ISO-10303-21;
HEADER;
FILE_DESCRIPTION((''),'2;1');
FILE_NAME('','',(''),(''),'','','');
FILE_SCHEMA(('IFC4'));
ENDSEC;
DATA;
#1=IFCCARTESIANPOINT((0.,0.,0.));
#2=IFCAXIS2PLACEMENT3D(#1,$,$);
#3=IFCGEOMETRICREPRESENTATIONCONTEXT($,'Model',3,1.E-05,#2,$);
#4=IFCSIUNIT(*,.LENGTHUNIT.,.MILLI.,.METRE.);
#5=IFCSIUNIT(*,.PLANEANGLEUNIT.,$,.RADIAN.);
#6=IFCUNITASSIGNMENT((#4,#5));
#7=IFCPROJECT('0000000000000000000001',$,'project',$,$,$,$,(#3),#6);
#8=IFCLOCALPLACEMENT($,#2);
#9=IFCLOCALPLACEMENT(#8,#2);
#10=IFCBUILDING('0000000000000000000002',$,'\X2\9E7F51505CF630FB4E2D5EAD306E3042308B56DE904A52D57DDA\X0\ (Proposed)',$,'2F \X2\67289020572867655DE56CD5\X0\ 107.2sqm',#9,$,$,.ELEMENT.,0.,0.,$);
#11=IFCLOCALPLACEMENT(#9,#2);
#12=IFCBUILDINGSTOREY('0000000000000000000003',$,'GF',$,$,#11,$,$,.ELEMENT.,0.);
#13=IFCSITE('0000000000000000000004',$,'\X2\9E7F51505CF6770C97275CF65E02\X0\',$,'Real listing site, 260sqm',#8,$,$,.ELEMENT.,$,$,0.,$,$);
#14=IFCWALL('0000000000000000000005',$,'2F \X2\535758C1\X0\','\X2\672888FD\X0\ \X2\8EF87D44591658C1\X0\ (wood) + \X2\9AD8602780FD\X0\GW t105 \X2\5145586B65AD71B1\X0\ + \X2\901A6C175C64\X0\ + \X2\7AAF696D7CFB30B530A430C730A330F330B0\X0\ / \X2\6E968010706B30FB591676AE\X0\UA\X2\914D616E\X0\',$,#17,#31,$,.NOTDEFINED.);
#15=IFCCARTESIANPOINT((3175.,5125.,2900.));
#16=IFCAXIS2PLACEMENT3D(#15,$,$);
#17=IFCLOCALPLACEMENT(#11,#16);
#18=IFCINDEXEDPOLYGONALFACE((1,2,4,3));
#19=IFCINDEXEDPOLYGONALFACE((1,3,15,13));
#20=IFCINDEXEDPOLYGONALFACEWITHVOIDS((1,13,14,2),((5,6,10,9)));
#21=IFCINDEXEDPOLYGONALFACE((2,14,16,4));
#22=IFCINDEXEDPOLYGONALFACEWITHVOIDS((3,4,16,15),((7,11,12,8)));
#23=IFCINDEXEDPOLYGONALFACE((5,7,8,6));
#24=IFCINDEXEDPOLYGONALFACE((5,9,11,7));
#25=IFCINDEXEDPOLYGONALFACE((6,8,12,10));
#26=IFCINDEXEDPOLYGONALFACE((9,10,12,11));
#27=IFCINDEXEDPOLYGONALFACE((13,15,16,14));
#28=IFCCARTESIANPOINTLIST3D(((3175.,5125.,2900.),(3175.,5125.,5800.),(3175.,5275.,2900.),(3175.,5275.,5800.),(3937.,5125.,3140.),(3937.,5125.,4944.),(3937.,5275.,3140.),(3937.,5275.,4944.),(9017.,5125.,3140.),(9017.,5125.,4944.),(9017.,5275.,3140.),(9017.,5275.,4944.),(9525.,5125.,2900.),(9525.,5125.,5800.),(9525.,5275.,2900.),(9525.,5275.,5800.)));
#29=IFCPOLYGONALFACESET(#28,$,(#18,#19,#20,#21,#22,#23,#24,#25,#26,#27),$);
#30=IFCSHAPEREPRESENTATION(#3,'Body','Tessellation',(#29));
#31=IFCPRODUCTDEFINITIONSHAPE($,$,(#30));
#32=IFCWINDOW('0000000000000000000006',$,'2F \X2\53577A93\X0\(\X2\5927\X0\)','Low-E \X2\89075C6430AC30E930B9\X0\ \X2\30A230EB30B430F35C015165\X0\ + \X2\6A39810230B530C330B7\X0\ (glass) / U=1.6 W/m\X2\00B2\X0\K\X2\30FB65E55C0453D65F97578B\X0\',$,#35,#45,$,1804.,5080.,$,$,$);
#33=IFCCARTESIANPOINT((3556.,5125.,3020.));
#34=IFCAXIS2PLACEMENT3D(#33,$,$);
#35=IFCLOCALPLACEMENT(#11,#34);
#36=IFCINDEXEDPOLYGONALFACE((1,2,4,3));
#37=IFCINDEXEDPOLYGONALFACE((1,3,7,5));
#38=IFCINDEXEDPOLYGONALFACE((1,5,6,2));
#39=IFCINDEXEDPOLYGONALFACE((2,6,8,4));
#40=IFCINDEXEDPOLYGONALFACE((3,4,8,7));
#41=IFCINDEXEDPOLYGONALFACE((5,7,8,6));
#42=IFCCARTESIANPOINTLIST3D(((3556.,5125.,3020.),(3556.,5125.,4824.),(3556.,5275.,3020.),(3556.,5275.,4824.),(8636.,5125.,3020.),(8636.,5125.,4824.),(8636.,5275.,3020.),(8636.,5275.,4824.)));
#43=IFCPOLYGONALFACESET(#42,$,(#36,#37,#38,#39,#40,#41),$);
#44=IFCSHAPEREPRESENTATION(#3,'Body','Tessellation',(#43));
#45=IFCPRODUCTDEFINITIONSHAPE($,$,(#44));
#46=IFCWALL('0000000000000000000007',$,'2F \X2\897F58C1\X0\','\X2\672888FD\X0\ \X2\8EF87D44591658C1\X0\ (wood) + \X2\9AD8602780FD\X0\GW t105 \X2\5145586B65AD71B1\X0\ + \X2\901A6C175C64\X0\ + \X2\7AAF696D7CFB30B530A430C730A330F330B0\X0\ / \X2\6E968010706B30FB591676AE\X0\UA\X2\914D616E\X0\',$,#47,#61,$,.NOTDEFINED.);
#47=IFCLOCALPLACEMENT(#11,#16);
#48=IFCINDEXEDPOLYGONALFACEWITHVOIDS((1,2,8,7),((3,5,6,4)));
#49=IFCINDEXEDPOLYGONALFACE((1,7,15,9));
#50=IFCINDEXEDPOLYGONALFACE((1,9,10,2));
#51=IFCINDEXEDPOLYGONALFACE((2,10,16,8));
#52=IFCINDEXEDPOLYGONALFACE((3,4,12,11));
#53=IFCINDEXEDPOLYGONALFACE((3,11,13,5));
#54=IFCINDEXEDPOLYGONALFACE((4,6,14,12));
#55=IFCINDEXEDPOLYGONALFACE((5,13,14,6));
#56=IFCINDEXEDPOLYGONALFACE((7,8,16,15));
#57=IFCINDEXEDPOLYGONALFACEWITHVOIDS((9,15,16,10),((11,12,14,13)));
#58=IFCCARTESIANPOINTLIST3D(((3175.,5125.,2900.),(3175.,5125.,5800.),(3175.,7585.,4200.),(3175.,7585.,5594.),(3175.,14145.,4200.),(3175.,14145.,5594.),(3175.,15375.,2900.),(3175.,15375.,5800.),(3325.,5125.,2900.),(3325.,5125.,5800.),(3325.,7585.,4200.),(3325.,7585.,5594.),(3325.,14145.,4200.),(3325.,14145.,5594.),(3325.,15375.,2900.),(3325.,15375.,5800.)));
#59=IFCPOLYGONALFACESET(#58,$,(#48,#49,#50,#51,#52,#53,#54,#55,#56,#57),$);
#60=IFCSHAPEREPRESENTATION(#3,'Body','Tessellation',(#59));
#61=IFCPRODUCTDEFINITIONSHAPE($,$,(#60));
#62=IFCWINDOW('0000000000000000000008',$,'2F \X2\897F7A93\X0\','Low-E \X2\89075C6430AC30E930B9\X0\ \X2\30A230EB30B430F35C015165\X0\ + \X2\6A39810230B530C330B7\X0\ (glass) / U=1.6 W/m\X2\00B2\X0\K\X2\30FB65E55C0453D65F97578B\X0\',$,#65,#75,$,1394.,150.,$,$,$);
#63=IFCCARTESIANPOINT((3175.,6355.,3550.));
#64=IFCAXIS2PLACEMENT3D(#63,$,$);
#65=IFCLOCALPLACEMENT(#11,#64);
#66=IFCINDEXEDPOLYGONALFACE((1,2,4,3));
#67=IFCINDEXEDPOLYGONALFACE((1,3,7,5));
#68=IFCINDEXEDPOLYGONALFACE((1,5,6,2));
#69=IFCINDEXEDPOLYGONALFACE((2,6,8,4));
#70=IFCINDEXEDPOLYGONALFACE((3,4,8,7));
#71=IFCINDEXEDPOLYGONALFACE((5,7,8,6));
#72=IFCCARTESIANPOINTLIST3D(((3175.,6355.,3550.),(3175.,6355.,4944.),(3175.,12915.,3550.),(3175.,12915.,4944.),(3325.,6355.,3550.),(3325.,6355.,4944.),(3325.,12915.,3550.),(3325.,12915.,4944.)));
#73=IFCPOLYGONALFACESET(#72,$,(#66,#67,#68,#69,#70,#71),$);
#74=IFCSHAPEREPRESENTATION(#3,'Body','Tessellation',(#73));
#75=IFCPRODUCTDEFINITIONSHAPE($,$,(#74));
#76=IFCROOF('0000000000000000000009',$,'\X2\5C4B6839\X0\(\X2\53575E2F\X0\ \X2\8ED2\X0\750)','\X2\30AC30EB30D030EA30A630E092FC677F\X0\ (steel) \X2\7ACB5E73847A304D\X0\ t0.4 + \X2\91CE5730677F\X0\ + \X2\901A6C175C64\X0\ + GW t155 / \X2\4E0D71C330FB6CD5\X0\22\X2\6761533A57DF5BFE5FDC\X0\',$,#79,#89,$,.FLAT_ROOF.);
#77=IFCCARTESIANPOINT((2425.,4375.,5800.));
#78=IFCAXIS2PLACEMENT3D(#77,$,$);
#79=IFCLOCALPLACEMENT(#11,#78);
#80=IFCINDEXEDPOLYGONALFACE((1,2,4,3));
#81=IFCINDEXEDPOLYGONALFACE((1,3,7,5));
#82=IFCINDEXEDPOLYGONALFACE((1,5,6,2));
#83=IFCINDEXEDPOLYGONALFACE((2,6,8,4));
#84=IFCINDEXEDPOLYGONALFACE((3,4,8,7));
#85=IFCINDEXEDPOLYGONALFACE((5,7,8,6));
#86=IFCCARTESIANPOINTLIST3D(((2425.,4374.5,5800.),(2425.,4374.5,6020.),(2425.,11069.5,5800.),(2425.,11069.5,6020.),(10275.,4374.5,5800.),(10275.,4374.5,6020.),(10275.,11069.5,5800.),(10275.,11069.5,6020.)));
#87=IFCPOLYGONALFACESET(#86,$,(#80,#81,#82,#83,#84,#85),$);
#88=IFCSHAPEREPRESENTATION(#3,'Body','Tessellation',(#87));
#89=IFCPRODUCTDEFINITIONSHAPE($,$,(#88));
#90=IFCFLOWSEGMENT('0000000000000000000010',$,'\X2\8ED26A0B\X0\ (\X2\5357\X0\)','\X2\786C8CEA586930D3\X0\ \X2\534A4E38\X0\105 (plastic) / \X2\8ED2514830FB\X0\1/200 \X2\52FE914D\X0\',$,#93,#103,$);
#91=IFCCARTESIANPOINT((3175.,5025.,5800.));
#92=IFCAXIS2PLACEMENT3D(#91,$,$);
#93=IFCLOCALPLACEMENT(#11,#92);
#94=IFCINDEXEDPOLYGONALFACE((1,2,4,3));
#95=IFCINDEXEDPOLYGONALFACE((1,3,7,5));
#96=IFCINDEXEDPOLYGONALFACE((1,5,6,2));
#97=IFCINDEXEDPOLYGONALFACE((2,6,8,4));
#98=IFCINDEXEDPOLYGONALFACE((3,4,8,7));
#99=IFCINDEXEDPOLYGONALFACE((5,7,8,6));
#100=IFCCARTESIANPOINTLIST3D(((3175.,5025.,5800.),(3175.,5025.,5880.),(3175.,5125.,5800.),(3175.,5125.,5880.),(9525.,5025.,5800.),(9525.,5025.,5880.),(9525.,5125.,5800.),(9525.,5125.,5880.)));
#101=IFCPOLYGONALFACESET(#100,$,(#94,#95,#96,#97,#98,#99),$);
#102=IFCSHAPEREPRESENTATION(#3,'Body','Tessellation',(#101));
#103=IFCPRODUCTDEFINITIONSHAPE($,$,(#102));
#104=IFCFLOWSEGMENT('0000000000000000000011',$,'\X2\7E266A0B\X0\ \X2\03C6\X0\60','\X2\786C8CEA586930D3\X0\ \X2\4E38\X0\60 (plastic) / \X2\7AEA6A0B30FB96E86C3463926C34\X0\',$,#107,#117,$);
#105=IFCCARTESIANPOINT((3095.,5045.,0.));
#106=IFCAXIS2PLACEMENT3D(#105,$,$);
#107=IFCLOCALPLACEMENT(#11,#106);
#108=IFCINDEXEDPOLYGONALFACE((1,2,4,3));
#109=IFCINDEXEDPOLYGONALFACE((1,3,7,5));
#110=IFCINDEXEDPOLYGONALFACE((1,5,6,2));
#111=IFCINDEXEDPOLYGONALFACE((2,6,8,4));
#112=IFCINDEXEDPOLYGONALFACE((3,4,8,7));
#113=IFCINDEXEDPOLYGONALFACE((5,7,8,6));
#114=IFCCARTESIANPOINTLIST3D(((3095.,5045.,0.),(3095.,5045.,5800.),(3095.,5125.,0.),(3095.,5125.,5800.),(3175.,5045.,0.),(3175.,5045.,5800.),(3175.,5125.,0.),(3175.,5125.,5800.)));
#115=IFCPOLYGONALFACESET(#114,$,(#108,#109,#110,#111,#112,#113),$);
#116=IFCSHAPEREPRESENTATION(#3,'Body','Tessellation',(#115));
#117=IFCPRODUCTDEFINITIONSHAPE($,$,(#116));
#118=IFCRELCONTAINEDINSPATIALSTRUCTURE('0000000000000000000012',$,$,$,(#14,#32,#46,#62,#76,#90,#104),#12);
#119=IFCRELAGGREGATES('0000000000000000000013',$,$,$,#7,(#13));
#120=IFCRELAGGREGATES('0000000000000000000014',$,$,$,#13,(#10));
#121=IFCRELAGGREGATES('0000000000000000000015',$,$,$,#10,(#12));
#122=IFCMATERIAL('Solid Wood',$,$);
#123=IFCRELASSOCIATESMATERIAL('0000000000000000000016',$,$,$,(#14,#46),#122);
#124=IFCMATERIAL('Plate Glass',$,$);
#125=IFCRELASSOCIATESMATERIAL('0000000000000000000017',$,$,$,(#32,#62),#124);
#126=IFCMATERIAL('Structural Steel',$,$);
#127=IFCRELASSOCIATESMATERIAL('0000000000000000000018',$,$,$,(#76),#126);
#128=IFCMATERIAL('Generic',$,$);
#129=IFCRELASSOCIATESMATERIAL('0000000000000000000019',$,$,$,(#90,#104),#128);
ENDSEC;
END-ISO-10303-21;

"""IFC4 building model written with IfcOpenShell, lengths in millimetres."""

from ifc_helpers import new_model, si_unit, frame, frame_2d, origin, place, context, project, spatial, rectangle, extrude, material, element, fill, save


model = new_model("IFC4")

# Units and contexts
model_context = context("Model", 3, precision=1e-05, world=origin())
ifc_project = project(units=[si_unit("LENGTHUNIT", "METRE", prefix="MILLI"), si_unit("PLANEANGLEUNIT", "RADIAN")], contexts=[model_context])

# Site, building, storey
site_placement = place(None, origin())
site = spatial("IfcSite", under=ifc_project, at=site_placement, Name="鹿児島県霧島市", ObjectType="Real listing site, 260sqm", CompositionType="ELEMENT", RefElevation=0.0)
building_placement = place(site_placement, origin())
building = spatial("IfcBuilding", under=site, at=building_placement, Name="鹿児島・中庭のある回遊動線 (Proposed)", ObjectType="2F 木造在来工法 107.2sqm", CompositionType="ELEMENT", ElevationOfRefHeight=0.0, ElevationOfTerrain=0.0)
storey_placement = place(building_placement, origin())
storey = spatial("IfcBuildingStorey", under=building, at=storey_placement, Name="GF", CompositionType="ELEMENT", Elevation=0.0)

# Shared definitions
ifc_material_1 = material(Name="Solid Wood")

# Shared definitions
ifc_material_2 = material(Name="Plate Glass")

# Walls, openings, windows
wall_1_placement = place(storey_placement, frame((3175.0, 5125.0, 2900.0)))
wall_1 = element("IfcWall", 1, at=wall_1_placement, inside=storey, material=ifc_material_1, Name="2F 南壁", Description="木製 軸組外壁 (wood) + 高性能GW t105 充填断熱 + 通気層 + 窯業系サイディング / 準耐火・外皮UA配慮", PredefinedType="NOTDEFINED", context=model_context, shape_type="SweptSolid", body=[
    extrude(rectangle(XDim=6350.0, YDim=150.0, at=frame_2d((3175.0, 75.0))), frame((3175.0, 5125.0, 2900.0)), (0.0, 0.0, 1.0), 2900.0),
])
opening_1_placement = place(storey_placement, frame((3556.0, 5125.0, 3020.0)))
opening_1 = element("IfcOpeningElement", 2, at=opening_1_placement, cuts=wall_1, PredefinedType="NOTDEFINED", context=model_context, shape_type="SweptSolid", body=[
    extrude(rectangle(XDim=5080.0, YDim=150.0, at=frame_2d((2540.0, 75.0))), frame((3556.0, 5125.0, 3020.0)), (0.0, 0.0, 1.0), 1804.0),
])
window_1_placement = place(storey_placement, frame((3556.0, 5125.0, 3020.0)))
window_1 = element("IfcWindow", 3, at=window_1_placement, inside=storey, material=ifc_material_2, Name="2F 南窓(大)", Description="Low-E 複層ガラス アルゴン封入 + 樹脂サッシ (glass) / U=1.6 W/m²K・日射取得型", OverallHeight=1804.0, OverallWidth=5080.0, context=model_context, shape_type="SweptSolid", body=[
    extrude(rectangle(XDim=5080.0, YDim=150.0, at=frame_2d((2540.0, 75.0))), frame((3556.0, 5125.0, 3020.0)), (0.0, 0.0, 1.0), 1804.0),
])
fill(opening_1, window_1)
wall_2_placement = place(storey_placement, frame((3175.0, 5125.0, 2900.0)))
wall_2 = element("IfcWall", 4, at=wall_2_placement, inside=storey, material=ifc_material_1, Name="2F 西壁", Description="木製 軸組外壁 (wood) + 高性能GW t105 充填断熱 + 通気層 + 窯業系サイディング / 準耐火・外皮UA配慮", PredefinedType="NOTDEFINED", context=model_context, shape_type="SweptSolid", body=[
    extrude(rectangle(XDim=150.0, YDim=10250.0, at=frame_2d((75.0, 5125.0))), frame((3175.0, 5125.0, 2900.0)), (0.0, 0.0, 1.0), 2900.0),
])
opening_2_placement = place(storey_placement, frame((3175.0, 6355.0, 3550.0)))
opening_2 = element("IfcOpeningElement", 5, at=opening_2_placement, cuts=wall_2, PredefinedType="NOTDEFINED", context=model_context, shape_type="SweptSolid", body=[
    extrude(rectangle(XDim=150.0, YDim=6560.0, at=frame_2d((75.0, 3280.0))), frame((3175.0, 6355.0, 3550.0)), (0.0, 0.0, 1.0), 1394.0),
])
window_2_placement = place(storey_placement, frame((3175.0, 6355.0, 3550.0)))
window_2 = element("IfcWindow", 6, at=window_2_placement, inside=storey, material=ifc_material_2, Name="2F 西窓", Description="Low-E 複層ガラス アルゴン封入 + 樹脂サッシ (glass) / U=1.6 W/m²K・日射取得型", OverallHeight=1394.0, OverallWidth=150.0, context=model_context, shape_type="SweptSolid", body=[
    extrude(rectangle(XDim=150.0, YDim=6560.0, at=frame_2d((75.0, 3280.0))), frame((3175.0, 6355.0, 3550.0)), (0.0, 0.0, 1.0), 1394.0),
])
fill(opening_2, window_2)

# Roof
ifc_material_3 = material(Name="Structural Steel")
for number, where, name in (
    (7, (2425.0, 4375.0, 5800.0), "屋根(南帯 軒750)"),
):
    element("IfcRoof", number, at=place(storey_placement, frame(where)), inside=storey, material=ifc_material_3, Name=name, Description="ガルバリウム鋼板 (steel) 立平葺き t0.4 + 野地板 + 通気層 + GW t155 / 不燃・法22条区域対応", PredefinedType="FLAT_ROOF", context=model_context, shape_type="SweptSolid", body=[
        extrude(rectangle(XDim=7850.0, YDim=6695.0, at=frame_2d((3925.0, 3347.0))), frame((2425.0, 4375.0, 5800.0)), (0.0, 0.0, 1.0), 220.0),
    ])

# Flow segments
ifc_material_4 = material(Name="Generic")
flow_segment_1_placement = place(storey_placement, frame((3175.0, 5025.0, 5800.0)))
element("IfcFlowSegment", 8, at=flow_segment_1_placement, inside=storey, material=ifc_material_4, Name="軒樋 (南)", Description="硬質塩ビ 半丸105 (plastic) / 軒先・1/200 勾配", context=model_context, shape_type="SweptSolid", body=[
    extrude(rectangle(XDim=6350.0, YDim=100.0, at=frame_2d((3175.0, 50.0))), frame((3175.0, 5025.0, 5800.0)), (0.0, 0.0, 1.0), 80.0),
])
flow_segment_2_placement = place(storey_placement, frame((3095.0, 5045.0, 0.0)))
element("IfcFlowSegment", 9, at=flow_segment_2_placement, inside=storey, material=ifc_material_4, Name="縦樋 φ60", Description="硬質塩ビ 丸60 (plastic) / 竪樋・雨水排水", context=model_context, shape_type="SweptSolid", body=[
    extrude(rectangle(XDim=80.0, YDim=80.0, at=frame_2d((40.0, 40.0))), frame((3095.0, 5045.0, 0.0)), (0.0, 0.0, 1.0), 5800.0),
])

save(model, "model.ifc")
